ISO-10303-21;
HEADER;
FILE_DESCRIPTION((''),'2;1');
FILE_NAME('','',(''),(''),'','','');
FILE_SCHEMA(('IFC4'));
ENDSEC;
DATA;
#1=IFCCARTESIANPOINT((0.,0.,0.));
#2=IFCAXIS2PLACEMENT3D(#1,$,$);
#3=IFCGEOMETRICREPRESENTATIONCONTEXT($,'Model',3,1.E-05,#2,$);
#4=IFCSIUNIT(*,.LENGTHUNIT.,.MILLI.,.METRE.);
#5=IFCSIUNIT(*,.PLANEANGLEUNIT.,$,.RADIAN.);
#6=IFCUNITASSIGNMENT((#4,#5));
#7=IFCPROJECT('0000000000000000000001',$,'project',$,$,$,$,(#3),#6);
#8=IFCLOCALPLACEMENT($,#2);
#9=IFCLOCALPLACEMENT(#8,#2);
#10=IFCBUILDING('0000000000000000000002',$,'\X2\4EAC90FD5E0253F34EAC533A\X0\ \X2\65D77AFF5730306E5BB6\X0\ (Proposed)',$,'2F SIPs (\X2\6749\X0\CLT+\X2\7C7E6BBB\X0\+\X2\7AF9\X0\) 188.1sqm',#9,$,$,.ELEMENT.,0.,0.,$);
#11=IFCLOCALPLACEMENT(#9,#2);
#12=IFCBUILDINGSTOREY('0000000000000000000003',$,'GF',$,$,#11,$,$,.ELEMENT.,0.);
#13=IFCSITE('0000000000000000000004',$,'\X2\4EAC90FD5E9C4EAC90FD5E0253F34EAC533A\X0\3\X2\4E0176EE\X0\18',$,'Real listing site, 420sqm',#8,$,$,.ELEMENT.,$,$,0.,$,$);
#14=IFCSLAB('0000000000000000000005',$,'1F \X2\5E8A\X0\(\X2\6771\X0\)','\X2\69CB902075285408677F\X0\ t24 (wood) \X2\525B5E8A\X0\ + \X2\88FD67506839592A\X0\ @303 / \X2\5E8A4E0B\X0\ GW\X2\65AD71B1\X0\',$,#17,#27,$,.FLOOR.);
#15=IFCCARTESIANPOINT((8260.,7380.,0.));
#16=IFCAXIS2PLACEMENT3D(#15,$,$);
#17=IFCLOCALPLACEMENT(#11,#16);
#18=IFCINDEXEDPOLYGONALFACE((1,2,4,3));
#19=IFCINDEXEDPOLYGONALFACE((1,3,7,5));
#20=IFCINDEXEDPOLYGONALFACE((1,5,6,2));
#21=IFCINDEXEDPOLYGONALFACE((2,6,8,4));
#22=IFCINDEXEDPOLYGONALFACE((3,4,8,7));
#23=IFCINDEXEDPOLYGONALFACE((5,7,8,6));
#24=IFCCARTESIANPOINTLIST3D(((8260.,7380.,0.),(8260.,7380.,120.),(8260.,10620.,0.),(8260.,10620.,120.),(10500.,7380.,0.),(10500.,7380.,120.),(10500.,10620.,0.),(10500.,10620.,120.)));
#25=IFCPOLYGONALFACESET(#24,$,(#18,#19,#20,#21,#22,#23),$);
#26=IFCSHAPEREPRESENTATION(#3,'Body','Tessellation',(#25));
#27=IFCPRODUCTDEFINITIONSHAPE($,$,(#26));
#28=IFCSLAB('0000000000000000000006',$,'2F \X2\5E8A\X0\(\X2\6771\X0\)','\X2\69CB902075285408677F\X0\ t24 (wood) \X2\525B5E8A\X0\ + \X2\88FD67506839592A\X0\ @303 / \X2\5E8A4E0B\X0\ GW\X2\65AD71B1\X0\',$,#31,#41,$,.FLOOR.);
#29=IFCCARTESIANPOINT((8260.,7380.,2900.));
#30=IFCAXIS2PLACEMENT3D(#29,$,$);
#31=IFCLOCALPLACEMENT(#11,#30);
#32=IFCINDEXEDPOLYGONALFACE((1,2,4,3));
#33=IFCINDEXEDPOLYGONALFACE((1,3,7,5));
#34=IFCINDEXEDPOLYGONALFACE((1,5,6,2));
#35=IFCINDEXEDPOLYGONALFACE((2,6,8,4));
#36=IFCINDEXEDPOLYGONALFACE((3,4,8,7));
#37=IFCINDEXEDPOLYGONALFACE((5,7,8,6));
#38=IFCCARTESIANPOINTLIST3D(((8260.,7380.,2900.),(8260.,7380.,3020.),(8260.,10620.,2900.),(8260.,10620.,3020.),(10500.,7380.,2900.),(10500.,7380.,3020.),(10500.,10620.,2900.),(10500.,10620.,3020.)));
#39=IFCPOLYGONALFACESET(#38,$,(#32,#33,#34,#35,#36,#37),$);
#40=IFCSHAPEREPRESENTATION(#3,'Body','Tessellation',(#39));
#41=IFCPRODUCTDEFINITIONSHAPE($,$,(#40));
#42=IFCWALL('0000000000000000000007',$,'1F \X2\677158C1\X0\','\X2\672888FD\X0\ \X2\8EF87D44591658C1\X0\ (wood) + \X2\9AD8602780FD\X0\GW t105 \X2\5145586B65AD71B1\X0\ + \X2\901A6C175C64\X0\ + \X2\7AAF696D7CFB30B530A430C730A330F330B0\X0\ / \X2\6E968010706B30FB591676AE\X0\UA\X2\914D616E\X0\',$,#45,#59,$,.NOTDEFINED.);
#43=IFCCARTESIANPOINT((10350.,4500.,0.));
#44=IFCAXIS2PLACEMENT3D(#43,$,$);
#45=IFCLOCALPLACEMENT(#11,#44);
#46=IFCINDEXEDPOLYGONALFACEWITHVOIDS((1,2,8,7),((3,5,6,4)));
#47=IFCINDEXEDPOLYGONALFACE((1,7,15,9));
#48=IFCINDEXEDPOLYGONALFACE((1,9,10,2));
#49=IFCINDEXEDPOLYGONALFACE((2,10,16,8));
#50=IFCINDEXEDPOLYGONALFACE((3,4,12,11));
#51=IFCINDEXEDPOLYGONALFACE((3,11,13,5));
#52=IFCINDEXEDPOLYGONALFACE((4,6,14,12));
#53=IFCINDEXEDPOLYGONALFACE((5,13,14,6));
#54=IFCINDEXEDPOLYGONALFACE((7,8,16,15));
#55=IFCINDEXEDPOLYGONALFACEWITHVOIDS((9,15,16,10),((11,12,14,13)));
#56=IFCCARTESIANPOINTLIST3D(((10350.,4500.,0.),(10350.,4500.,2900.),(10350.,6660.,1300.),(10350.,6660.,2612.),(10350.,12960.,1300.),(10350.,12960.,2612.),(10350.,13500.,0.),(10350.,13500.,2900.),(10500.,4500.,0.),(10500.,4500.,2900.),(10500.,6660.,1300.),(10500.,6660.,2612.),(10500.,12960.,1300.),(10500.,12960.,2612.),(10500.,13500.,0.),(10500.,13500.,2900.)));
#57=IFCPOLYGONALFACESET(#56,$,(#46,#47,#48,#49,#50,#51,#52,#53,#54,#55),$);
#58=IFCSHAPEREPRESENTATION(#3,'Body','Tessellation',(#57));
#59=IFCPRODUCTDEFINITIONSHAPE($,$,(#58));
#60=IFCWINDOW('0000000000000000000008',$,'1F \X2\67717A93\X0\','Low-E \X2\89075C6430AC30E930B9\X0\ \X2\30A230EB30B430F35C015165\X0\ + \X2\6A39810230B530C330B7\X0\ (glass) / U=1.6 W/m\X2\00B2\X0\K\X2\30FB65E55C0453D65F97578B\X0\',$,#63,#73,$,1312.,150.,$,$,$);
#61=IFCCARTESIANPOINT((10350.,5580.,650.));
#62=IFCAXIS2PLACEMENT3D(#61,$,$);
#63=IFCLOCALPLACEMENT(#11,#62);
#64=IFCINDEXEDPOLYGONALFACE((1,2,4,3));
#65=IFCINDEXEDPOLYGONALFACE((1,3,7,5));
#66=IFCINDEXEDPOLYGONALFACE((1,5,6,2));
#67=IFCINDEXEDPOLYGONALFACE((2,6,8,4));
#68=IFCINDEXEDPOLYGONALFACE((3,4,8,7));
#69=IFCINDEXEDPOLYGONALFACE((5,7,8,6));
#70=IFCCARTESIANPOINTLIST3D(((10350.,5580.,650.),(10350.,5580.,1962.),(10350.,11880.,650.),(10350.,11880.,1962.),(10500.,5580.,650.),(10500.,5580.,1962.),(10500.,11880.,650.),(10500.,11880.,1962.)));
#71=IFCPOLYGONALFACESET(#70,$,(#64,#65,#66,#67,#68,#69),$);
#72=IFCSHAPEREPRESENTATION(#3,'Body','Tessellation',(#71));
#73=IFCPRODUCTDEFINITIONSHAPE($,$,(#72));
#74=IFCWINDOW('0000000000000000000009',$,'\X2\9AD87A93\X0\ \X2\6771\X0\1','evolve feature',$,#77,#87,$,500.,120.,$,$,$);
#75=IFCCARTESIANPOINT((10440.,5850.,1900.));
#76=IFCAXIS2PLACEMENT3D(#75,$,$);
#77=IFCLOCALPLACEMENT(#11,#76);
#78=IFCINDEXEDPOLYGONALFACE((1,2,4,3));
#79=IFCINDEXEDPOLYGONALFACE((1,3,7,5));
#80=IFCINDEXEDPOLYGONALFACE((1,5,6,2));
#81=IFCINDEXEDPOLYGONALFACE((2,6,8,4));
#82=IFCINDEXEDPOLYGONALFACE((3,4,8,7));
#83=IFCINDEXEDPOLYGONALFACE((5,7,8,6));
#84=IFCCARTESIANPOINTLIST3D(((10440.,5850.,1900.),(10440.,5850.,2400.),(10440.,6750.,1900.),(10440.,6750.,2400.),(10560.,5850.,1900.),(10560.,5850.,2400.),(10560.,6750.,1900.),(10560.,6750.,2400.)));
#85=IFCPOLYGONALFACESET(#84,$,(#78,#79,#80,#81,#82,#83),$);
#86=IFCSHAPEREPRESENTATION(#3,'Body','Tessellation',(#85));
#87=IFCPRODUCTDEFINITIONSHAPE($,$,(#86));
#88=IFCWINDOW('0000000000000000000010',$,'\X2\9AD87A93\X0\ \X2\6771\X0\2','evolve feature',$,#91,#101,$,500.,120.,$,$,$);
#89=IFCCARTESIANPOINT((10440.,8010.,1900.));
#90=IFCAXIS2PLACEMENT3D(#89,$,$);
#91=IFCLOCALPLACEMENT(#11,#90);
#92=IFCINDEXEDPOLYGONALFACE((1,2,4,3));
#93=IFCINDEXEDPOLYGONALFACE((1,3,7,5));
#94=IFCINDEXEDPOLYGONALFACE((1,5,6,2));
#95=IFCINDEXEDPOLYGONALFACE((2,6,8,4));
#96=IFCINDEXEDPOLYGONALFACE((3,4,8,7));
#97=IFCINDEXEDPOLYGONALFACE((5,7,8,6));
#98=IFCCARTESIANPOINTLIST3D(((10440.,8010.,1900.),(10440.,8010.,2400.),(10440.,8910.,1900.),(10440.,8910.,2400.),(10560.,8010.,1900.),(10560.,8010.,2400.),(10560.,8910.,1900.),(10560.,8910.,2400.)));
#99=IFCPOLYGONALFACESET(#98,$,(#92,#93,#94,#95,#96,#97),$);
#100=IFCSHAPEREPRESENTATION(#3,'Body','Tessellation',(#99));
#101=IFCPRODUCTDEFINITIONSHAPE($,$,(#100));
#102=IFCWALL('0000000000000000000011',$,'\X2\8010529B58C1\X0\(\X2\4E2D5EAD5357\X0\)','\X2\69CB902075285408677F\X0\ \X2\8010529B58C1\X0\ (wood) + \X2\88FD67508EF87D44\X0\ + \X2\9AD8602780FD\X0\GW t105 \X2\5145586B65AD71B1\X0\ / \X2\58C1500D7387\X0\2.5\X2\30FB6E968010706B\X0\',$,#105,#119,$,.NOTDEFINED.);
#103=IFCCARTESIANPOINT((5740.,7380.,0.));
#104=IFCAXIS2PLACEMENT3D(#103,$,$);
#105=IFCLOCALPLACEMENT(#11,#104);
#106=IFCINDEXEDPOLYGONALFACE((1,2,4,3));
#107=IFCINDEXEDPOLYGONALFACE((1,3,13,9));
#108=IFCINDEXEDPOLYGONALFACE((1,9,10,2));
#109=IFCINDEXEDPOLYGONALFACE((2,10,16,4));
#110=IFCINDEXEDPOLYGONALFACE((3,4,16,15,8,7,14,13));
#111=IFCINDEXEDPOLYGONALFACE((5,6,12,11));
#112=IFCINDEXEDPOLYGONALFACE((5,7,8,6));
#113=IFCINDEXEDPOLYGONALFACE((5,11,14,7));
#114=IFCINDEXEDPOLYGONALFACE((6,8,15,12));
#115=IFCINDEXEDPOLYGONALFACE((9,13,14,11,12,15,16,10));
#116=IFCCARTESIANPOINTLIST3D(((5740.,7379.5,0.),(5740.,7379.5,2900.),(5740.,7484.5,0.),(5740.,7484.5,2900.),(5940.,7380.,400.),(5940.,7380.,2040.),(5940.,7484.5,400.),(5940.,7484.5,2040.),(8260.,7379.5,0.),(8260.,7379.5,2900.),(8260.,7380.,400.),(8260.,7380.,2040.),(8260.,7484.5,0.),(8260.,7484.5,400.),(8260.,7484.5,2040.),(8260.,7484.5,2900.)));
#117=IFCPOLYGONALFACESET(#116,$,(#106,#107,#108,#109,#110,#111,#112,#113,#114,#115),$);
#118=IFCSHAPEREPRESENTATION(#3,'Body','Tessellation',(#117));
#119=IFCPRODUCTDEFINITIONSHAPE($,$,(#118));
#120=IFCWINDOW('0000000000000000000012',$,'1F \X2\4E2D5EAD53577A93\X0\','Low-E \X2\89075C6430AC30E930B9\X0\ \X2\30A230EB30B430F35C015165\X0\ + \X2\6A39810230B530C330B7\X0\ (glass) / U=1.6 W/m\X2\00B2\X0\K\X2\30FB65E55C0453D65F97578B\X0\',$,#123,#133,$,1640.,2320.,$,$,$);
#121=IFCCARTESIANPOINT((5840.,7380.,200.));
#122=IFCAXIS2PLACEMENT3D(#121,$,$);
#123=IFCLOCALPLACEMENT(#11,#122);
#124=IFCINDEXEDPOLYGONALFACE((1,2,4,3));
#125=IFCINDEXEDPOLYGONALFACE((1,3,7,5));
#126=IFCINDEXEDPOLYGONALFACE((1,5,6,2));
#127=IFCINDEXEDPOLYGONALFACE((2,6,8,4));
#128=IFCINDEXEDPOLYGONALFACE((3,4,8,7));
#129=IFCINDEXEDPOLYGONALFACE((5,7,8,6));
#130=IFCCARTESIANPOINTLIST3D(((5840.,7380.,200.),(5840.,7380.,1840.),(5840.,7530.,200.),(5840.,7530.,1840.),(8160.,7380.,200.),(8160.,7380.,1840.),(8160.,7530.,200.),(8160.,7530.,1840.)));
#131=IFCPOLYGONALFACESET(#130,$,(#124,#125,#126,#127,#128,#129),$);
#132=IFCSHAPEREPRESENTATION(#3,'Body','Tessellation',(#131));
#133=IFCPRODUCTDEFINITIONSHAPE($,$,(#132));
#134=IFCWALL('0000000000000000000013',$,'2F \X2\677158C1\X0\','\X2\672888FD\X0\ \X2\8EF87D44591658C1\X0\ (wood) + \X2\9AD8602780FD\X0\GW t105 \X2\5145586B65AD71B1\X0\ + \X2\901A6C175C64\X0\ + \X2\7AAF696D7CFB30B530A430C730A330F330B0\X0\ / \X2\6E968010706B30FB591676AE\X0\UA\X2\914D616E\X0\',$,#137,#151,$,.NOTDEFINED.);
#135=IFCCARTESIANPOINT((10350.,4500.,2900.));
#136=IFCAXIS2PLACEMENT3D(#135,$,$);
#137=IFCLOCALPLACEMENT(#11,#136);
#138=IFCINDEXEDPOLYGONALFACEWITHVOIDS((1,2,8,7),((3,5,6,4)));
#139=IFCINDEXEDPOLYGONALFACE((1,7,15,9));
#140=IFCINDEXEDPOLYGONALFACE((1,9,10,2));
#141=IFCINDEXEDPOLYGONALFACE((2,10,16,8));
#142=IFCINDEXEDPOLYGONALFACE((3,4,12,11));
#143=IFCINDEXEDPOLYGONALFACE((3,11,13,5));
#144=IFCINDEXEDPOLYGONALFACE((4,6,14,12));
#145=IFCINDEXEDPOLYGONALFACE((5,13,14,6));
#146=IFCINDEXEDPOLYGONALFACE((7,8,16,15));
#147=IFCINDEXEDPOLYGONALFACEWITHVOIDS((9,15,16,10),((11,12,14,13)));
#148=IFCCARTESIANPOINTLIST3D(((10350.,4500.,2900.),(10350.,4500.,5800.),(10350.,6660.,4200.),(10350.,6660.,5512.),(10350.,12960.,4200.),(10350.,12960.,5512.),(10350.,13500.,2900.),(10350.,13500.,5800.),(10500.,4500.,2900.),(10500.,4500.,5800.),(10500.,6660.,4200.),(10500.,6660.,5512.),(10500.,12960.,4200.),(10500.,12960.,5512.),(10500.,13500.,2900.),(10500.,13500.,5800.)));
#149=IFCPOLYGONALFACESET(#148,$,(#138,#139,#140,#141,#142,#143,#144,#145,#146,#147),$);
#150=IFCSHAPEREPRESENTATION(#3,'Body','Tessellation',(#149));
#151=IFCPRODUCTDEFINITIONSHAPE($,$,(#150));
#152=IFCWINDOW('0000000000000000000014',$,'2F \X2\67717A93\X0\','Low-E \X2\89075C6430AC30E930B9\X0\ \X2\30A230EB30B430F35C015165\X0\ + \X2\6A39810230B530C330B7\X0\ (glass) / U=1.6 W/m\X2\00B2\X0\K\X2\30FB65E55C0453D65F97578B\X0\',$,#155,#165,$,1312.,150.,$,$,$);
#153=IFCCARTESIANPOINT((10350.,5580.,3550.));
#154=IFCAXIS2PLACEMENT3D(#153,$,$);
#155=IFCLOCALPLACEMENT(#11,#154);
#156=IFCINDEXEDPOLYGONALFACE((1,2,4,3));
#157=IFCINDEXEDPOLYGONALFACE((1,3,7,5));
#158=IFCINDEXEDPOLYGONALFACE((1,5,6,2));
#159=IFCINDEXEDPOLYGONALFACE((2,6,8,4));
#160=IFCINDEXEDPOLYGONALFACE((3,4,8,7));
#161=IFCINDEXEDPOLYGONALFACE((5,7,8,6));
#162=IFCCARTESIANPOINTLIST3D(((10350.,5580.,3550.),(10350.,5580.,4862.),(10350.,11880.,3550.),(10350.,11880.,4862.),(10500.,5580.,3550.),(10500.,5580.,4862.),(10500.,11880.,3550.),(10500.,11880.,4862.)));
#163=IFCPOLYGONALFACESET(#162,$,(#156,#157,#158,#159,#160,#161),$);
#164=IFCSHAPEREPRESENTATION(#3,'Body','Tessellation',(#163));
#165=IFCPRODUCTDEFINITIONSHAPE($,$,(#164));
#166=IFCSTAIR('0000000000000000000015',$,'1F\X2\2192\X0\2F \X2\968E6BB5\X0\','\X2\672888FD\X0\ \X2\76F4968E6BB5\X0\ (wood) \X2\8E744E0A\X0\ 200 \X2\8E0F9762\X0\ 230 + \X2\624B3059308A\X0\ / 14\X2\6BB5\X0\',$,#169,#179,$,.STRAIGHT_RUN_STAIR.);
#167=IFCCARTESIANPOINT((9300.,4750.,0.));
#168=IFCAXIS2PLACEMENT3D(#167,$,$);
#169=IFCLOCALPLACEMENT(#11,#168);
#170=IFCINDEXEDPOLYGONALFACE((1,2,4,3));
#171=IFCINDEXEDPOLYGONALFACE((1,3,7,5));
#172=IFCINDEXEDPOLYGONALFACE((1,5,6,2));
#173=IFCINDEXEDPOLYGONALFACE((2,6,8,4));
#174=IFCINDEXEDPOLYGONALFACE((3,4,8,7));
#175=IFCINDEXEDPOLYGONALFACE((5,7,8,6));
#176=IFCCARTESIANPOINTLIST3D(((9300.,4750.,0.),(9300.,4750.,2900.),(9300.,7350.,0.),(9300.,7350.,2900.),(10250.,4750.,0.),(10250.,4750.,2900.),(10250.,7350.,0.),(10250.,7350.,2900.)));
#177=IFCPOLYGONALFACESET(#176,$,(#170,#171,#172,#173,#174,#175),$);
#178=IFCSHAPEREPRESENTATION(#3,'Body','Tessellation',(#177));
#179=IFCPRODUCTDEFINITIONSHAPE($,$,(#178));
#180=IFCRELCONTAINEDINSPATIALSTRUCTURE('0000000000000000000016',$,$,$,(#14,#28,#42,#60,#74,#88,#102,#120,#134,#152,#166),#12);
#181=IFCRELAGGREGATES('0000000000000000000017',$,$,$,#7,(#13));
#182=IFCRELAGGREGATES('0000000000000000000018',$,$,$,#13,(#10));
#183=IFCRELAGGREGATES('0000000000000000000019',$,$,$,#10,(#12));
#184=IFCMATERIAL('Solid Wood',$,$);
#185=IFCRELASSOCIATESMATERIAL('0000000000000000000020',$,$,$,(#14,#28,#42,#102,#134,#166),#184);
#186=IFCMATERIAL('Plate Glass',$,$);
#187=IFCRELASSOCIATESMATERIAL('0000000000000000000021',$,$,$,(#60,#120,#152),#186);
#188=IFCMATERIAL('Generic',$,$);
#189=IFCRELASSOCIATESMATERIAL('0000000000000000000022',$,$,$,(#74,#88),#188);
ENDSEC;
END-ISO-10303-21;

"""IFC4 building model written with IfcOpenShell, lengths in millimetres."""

from ifc_helpers import new_model, si_unit, frame, frame_2d, origin, place, context, project, spatial, rectangle, extrude, material, element, fill, save


model = new_model("IFC4")

# Units and contexts
model_context = context("Model", 3, precision=1e-05, world=origin())
ifc_project = project(units=[si_unit("LENGTHUNIT", "METRE", prefix="MILLI"), si_unit("PLANEANGLEUNIT", "RADIAN")], contexts=[model_context])

# Site, building, storey
site_placement = place(None, origin())
site = spatial("IfcSite", under=ifc_project, at=site_placement, Name="京都府京都市右京区3丁目18", ObjectType="Real listing site, 420sqm", CompositionType="ELEMENT", RefElevation=0.0)
building_placement = place(site_placement, origin())
building = spatial("IfcBuilding", under=site, at=building_placement, Name="京都市右京区 旗竿地の家 (Proposed)", ObjectType="2F SIPs (杉CLT+籾殻+竹) 188.1sqm", CompositionType="ELEMENT", ElevationOfRefHeight=0.0, ElevationOfTerrain=0.0)
storey_placement = place(building_placement, origin())
storey = spatial("IfcBuildingStorey", under=building, at=storey_placement, Name="GF", CompositionType="ELEMENT", Elevation=0.0)

# Slabs
ifc_material_1 = material(Name="Solid Wood")
slab_1_placement = place(storey_placement, frame((8260.0, 7380.0, 0.0)))
element("IfcSlab", 1, at=slab_1_placement, inside=storey, material=ifc_material_1, Name="1F 床(東)", Description="構造用合板 t24 (wood) 剛床 + 製材根太 @303 / 床下 GW断熱", PredefinedType="FLOOR", context=model_context, shape_type="SweptSolid", body=[
    extrude(rectangle(XDim=2240.0, YDim=3240.0, at=frame_2d((1120.0, 1620.0))), frame((8260.0, 7380.0, 0.0)), (0.0, 0.0, 1.0), 120.0),
])
slab_2_placement = place(storey_placement, frame((8260.0, 7380.0, 2900.0)))
element("IfcSlab", 2, at=slab_2_placement, inside=storey, material=ifc_material_1, Name="2F 床(東)", Description="構造用合板 t24 (wood) 剛床 + 製材根太 @303 / 床下 GW断熱", PredefinedType="FLOOR", context=model_context, shape_type="SweptSolid", body=[
    extrude(rectangle(XDim=2240.0, YDim=3240.0, at=frame_2d((1120.0, 1620.0))), frame((8260.0, 7380.0, 2900.0)), (0.0, 0.0, 1.0), 120.0),
])

# Wall, openings, windows
wall_1_placement = place(storey_placement, frame((10350.0, 4500.0, 0.0)))
wall_1 = element("IfcWall", 3, at=wall_1_placement, inside=storey, material=ifc_material_1, Name="1F 東壁", Description="木製 軸組外壁 (wood) + 高性能GW t105 充填断熱 + 通気層 + 窯業系サイディング / 準耐火・外皮UA配慮", PredefinedType="NOTDEFINED", context=model_context, shape_type="SweptSolid", body=[
    extrude(rectangle(XDim=150.0, YDim=9000.0, at=frame_2d((75.0, 4500.0))), frame((10350.0, 4500.0, 0.0)), (0.0, 0.0, 1.0), 2900.0),
])
opening_1_placement = place(storey_placement, frame((10350.0, 5580.0, 650.0)))
opening_1 = element("IfcOpeningElement", 4, at=opening_1_placement, cuts=wall_1, PredefinedType="NOTDEFINED", context=model_context, shape_type="SweptSolid", body=[
    extrude(rectangle(XDim=150.0, YDim=6300.0, at=frame_2d((75.0, 3150.0))), frame((10350.0, 5580.0, 650.0)), (0.0, 0.0, 1.0), 1312.0),
])
opening_2_placement = place(storey_placement, frame((10440.0, 5850.0, 1900.0)))
opening_2 = element("IfcOpeningElement", 5, at=opening_2_placement, cuts=wall_1, PredefinedType="NOTDEFINED", context=model_context, shape_type="SweptSolid", body=[
    extrude(rectangle(XDim=120.0, YDim=900.0, at=frame_2d((60.0, 450.0))), frame((10440.0, 5850.0, 1900.0)), (0.0, 0.0, 1.0), 500.0),
])
opening_3_placement = place(storey_placement, frame((10440.0, 8010.0, 1900.0)))
opening_3 = element("IfcOpeningElement", 6, at=opening_3_placement, cuts=wall_1, PredefinedType="NOTDEFINED", context=model_context, shape_type="SweptSolid", body=[
    extrude(rectangle(XDim=120.0, YDim=900.0, at=frame_2d((60.0, 450.0))), frame((10440.0, 8010.0, 1900.0)), (0.0, 0.0, 1.0), 500.0),
])
ifc_material_2 = material(Name="Plate Glass")
window_1_placement = place(storey_placement, frame((10350.0, 5580.0, 650.0)))
window_1 = element("IfcWindow", 7, at=window_1_placement, inside=storey, material=ifc_material_2, Name="1F 東窓", Description="Low-E 複層ガラス アルゴン封入 + 樹脂サッシ (glass) / U=1.6 W/m²K・日射取得型", OverallHeight=1312.0, OverallWidth=150.0, context=model_context, shape_type="SweptSolid", body=[
    extrude(rectangle(XDim=150.0, YDim=6300.0, at=frame_2d((75.0, 3150.0))), frame((10350.0, 5580.0, 650.0)), (0.0, 0.0, 1.0), 1312.0),
])
fill(opening_1, window_1)
ifc_material_3 = material(Name="Generic")
window_2_placement = place(storey_placement, frame((10440.0, 5850.0, 1900.0)))
window_2 = element("IfcWindow", 8, at=window_2_placement, inside=storey, material=ifc_material_3, Name="高窓 東1", Description="evolve feature", OverallHeight=500.0, OverallWidth=120.0, context=model_context, shape_type="SweptSolid", body=[
    extrude(rectangle(XDim=120.0, YDim=900.0, at=frame_2d((60.0, 450.0))), frame((10440.0, 5850.0, 1900.0)), (0.0, 0.0, 1.0), 500.0),
])
fill(opening_2, window_2)
window_3_placement = place(storey_placement, frame((10440.0, 8010.0, 1900.0)))
window_3 = element("IfcWindow", 9, at=window_3_placement, inside=storey, material=ifc_material_3, Name="高窓 東2", Description="evolve feature", OverallHeight=500.0, OverallWidth=120.0, context=model_context, shape_type="SweptSolid", body=[
    extrude(rectangle(XDim=120.0, YDim=900.0, at=frame_2d((60.0, 450.0))), frame((10440.0, 8010.0, 1900.0)), (0.0, 0.0, 1.0), 500.0),
])
fill(opening_3, window_3)

# Wall, opening, window
wall_2_placement = place(storey_placement, frame((5740.0, 7380.0, 0.0)))
wall_2 = element("IfcWall", 10, at=wall_2_placement, inside=storey, material=ifc_material_1, Name="耐力壁(中庭南)", Description="構造用合板 耐力壁 (wood) + 製材軸組 + 高性能GW t105 充填断熱 / 壁倍率2.5・準耐火", PredefinedType="NOTDEFINED", context=model_context, shape_type="SweptSolid", body=[
    extrude(rectangle(XDim=2520.0, YDim=105.0, at=frame_2d((1260.0, 52.0))), frame((5740.0, 7380.0, 0.0)), (0.0, 0.0, 1.0), 2900.0),
])
opening_4_placement = place(storey_placement, frame((5840.0, 7380.0, 200.0)))
opening_4 = element("IfcOpeningElement", 11, at=opening_4_placement, cuts=wall_2, PredefinedType="NOTDEFINED", context=model_context, shape_type="SweptSolid", body=[
    extrude(rectangle(XDim=2320.0, YDim=150.0, at=frame_2d((1160.0, 75.0))), frame((5840.0, 7380.0, 200.0)), (0.0, 0.0, 1.0), 1640.0),
])
window_4_placement = place(storey_placement, frame((5840.0, 7380.0, 200.0)))
window_4 = element("IfcWindow", 12, at=window_4_placement, inside=storey, material=ifc_material_2, Name="1F 中庭南窓", Description="Low-E 複層ガラス アルゴン封入 + 樹脂サッシ (glass) / U=1.6 W/m²K・日射取得型", OverallHeight=1640.0, OverallWidth=2320.0, context=model_context, shape_type="SweptSolid", body=[
    extrude(rectangle(XDim=2320.0, YDim=150.0, at=frame_2d((1160.0, 75.0))), frame((5840.0, 7380.0, 200.0)), (0.0, 0.0, 1.0), 1640.0),
])
fill(opening_4, window_4)

# Wall, opening, window
wall_3_placement = place(storey_placement, frame((10350.0, 4500.0, 2900.0)))
wall_3 = element("IfcWall", 13, at=wall_3_placement, inside=storey, material=ifc_material_1, Name="2F 東壁", Description="木製 軸組外壁 (wood) + 高性能GW t105 充填断熱 + 通気層 + 窯業系サイディング / 準耐火・外皮UA配慮", PredefinedType="NOTDEFINED", context=model_context, shape_type="SweptSolid", body=[
    extrude(rectangle(XDim=150.0, YDim=9000.0, at=frame_2d((75.0, 4500.0))), frame((10350.0, 4500.0, 2900.0)), (0.0, 0.0, 1.0), 2900.0),
])
opening_5_placement = place(storey_placement, frame((10350.0, 5580.0, 3550.0)))
opening_5 = element("IfcOpeningElement", 14, at=opening_5_placement, cuts=wall_3, PredefinedType="NOTDEFINED", context=model_context, shape_type="SweptSolid", body=[
    extrude(rectangle(XDim=150.0, YDim=6300.0, at=frame_2d((75.0, 3150.0))), frame((10350.0, 5580.0, 3550.0)), (0.0, 0.0, 1.0), 1312.0),
])
window_5_placement = place(storey_placement, frame((10350.0, 5580.0, 3550.0)))
window_5 = element("IfcWindow", 15, at=window_5_placement, inside=storey, material=ifc_material_2, Name="2F 東窓", Description="Low-E 複層ガラス アルゴン封入 + 樹脂サッシ (glass) / U=1.6 W/m²K・日射取得型", OverallHeight=1312.0, OverallWidth=150.0, context=model_context, shape_type="SweptSolid", body=[
    extrude(rectangle(XDim=150.0, YDim=6300.0, at=frame_2d((75.0, 3150.0))), frame((10350.0, 5580.0, 3550.0)), (0.0, 0.0, 1.0), 1312.0),
])
fill(opening_5, window_5)

# Stair
stair_placement = place(storey_placement, frame((9300.0, 4750.0, 0.0)))
element("IfcStair", 16, at=stair_placement, inside=storey, material=ifc_material_1, Name="1F→2F 階段", Description="木製 直階段 (wood) 蹴上 200 踏面 230 + 手すり / 14段", PredefinedType="STRAIGHT_RUN_STAIR", context=model_context, shape_type="SweptSolid", body=[
    extrude(rectangle(XDim=950.0, YDim=2600.0, at=frame_2d((475.0, 1300.0))), frame((9300.0, 4750.0, 0.0)), (0.0, 0.0, 1.0), 2900.0),
])

save(model, "model.ifc")
